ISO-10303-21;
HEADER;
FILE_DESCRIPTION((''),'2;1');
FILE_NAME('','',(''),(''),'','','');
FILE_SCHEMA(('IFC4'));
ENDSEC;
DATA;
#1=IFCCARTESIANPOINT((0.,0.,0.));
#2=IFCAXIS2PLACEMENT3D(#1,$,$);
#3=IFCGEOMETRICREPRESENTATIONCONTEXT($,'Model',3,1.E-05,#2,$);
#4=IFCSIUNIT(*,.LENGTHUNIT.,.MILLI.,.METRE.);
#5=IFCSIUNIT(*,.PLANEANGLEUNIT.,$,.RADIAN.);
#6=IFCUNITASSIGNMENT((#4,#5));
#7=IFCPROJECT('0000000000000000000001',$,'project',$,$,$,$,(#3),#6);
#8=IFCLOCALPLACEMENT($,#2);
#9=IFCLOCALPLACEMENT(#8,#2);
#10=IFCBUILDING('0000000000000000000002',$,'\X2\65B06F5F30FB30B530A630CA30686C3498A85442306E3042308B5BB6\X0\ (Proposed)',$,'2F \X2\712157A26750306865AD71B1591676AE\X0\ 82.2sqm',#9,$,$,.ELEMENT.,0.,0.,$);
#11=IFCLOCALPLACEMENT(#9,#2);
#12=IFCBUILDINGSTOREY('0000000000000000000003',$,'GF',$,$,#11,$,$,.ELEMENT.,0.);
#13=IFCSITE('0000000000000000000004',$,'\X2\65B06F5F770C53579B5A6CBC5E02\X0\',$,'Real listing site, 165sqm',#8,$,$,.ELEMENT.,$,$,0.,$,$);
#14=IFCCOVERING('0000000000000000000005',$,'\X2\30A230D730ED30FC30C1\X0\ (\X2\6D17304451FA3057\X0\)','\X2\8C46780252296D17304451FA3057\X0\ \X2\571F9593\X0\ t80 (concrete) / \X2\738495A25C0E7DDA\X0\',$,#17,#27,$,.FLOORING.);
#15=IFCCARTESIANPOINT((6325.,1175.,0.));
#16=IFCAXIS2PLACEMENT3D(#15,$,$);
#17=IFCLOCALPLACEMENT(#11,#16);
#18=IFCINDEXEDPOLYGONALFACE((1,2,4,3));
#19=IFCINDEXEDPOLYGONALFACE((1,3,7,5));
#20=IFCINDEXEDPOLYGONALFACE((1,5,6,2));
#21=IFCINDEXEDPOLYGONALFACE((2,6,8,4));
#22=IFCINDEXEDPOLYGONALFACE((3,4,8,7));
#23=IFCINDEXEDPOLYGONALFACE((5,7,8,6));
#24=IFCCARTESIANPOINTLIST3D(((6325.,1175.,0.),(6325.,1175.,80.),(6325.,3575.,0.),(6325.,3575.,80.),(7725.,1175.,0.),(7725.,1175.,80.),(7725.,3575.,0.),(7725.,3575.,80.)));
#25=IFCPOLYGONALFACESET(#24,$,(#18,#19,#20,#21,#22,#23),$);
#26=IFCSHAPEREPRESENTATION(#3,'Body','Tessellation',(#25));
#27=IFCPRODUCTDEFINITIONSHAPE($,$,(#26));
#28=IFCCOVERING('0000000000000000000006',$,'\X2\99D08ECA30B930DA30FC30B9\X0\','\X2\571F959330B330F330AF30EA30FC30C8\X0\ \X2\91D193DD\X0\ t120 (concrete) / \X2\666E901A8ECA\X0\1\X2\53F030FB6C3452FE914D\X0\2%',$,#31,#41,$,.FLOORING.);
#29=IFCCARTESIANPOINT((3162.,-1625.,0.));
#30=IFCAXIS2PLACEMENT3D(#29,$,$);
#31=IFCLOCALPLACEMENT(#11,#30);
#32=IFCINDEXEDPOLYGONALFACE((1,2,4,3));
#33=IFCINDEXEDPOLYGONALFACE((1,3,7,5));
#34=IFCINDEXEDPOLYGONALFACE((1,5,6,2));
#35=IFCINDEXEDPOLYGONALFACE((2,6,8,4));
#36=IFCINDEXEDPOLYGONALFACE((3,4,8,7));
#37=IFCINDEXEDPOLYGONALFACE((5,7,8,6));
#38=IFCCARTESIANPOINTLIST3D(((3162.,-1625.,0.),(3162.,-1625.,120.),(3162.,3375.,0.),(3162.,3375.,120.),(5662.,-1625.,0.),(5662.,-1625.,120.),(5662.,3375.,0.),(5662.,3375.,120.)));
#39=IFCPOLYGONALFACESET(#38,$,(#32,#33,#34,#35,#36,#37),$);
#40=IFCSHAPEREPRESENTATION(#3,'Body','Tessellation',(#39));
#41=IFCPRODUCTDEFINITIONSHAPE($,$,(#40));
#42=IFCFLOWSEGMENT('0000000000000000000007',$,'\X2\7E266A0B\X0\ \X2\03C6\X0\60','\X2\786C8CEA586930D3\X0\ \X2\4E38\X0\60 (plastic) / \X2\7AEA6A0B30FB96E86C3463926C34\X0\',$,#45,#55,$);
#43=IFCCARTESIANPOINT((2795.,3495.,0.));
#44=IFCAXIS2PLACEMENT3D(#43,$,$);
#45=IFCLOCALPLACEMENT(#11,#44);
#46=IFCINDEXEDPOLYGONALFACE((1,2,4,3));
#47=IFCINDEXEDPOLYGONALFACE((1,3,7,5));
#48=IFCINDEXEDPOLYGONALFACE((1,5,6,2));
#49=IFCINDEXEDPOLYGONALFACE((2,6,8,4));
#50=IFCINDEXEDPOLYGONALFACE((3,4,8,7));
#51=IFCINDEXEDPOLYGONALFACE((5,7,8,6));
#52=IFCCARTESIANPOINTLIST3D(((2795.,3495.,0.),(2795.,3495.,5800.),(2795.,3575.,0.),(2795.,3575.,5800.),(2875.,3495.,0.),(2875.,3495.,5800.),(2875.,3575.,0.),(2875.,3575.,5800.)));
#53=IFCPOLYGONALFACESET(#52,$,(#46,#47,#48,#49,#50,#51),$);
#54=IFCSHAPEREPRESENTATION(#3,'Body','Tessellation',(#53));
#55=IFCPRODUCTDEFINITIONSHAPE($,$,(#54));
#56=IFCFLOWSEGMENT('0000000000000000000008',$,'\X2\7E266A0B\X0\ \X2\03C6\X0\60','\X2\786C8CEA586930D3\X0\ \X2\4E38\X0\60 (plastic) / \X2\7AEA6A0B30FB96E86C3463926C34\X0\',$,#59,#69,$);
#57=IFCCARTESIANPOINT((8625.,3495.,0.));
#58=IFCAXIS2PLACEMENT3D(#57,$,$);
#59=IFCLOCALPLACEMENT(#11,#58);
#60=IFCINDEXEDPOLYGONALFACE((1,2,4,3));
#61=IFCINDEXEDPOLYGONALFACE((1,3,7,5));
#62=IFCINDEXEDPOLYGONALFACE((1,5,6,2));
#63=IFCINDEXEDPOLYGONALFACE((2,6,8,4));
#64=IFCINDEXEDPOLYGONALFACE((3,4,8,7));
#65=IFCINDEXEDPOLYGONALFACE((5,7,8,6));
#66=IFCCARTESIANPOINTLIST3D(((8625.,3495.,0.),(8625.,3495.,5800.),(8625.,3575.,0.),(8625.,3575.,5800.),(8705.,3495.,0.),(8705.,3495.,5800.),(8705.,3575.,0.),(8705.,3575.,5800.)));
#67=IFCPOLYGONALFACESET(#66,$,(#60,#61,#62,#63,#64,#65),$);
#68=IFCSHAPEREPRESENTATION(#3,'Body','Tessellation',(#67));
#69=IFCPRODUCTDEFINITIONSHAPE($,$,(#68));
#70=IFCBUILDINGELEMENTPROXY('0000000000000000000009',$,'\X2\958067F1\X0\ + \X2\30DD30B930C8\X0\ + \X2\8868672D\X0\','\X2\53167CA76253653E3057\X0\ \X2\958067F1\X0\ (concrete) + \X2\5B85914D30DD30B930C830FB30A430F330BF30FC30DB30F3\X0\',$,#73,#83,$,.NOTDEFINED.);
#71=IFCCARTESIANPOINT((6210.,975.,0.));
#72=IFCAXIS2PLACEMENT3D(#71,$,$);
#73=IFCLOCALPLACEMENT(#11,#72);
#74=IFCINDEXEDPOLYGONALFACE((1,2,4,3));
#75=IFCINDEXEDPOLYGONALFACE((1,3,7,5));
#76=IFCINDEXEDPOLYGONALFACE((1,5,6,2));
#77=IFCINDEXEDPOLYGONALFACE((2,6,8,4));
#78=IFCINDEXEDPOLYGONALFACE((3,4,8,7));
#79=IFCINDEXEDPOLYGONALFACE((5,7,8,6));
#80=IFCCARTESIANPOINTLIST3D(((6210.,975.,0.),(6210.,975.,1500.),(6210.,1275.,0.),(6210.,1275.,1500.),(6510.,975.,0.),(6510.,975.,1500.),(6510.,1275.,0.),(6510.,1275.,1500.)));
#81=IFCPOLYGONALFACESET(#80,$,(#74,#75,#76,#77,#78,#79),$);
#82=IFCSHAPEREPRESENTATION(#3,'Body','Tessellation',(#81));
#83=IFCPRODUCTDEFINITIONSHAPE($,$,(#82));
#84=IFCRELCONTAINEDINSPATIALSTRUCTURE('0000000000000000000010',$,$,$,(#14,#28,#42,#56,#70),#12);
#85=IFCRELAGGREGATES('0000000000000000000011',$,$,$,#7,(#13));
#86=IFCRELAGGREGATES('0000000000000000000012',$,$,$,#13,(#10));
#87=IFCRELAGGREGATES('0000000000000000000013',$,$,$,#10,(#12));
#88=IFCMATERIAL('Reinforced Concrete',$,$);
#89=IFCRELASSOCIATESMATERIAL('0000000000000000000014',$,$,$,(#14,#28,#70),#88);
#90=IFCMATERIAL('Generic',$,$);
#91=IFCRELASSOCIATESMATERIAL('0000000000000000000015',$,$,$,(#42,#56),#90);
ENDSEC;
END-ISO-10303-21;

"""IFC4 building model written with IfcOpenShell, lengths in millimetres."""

from ifc_helpers import new_model, si_unit, frame, frame_2d, origin, place, context, project, spatial, rectangle, extrude, material, element, save


model = new_model("IFC4")

# Units and contexts
model_context = context("Model", 3, precision=1e-05, world=origin())
ifc_project = project(units=[si_unit("LENGTHUNIT", "METRE", prefix="MILLI"), si_unit("PLANEANGLEUNIT", "RADIAN")], contexts=[model_context])

# Site, building, storey
site_placement = place(None, origin())
site = spatial("IfcSite", under=ifc_project, at=site_placement, Name="新潟県南魚沼市", ObjectType="Real listing site, 165sqm", CompositionType="ELEMENT", RefElevation=0.0)
building_placement = place(site_placement, origin())
building = spatial("IfcBuilding", under=site, at=building_placement, Name="新潟・サウナと水風呂のある家 (Proposed)", ObjectType="2F 無垢材と断熱外皮 82.2sqm", CompositionType="ELEMENT", ElevationOfRefHeight=0.0, ElevationOfTerrain=0.0)
storey_placement = place(building_placement, origin())
storey = spatial("IfcBuildingStorey", under=building, at=storey_placement, Name="GF", CompositionType="ELEMENT", Elevation=0.0)

# Shared definitions
ifc_material_1 = material(Name="Reinforced Concrete")

# Coverings
covering_1_placement = place(storey_placement, frame((6325.0, 1175.0, 0.0)))
element("IfcCovering", 1, at=covering_1_placement, inside=storey, material=ifc_material_1, Name="アプローチ (洗い出し)", Description="豆砂利洗い出し 土間 t80 (concrete) / 玄関導線", PredefinedType="FLOORING", context=model_context, shape_type="SweptSolid", body=[
    extrude(rectangle(XDim=1400.0, YDim=2400.0, at=frame_2d((700.0, 1200.0))), frame((6325.0, 1175.0, 0.0)), (0.0, 0.0, 1.0), 80.0),
])
covering_2_placement = place(storey_placement, frame((3162.0, -1625.0, 0.0)))
element("IfcCovering", 2, at=covering_2_placement, inside=storey, material=ifc_material_1, Name="駐車スペース", Description="土間コンクリート 金鏝 t120 (concrete) / 普通車1台・水勾配2%", PredefinedType="FLOORING", context=model_context, shape_type="SweptSolid", body=[
    extrude(rectangle(XDim=2500.0, YDim=5000.0, at=frame_2d((1250.0, 2500.0))), frame((3162.0, -1625.0, 0.0)), (0.0, 0.0, 1.0), 120.0),
])

# Flow segments
ifc_material_2 = material(Name="Generic")
flow_segment_1_placement = place(storey_placement, frame((2795.0, 3495.0, 0.0)))
element("IfcFlowSegment", 3, at=flow_segment_1_placement, inside=storey, material=ifc_material_2, Name="縦樋 φ60", Description="硬質塩ビ 丸60 (plastic) / 竪樋・雨水排水", context=model_context, shape_type="SweptSolid", body=[
    extrude(rectangle(XDim=80.0, YDim=80.0, at=frame_2d((40.0, 40.0))), frame((2795.0, 3495.0, 0.0)), (0.0, 0.0, 1.0), 5800.0),
])
flow_segment_2_placement = place(storey_placement, frame((8625.0, 3495.0, 0.0)))
element("IfcFlowSegment", 4, at=flow_segment_2_placement, inside=storey, material=ifc_material_2, Name="縦樋 φ60", Description="硬質塩ビ 丸60 (plastic) / 竪樋・雨水排水", context=model_context, shape_type="SweptSolid", body=[
    extrude(rectangle(XDim=80.0, YDim=80.0, at=frame_2d((40.0, 40.0))), frame((8625.0, 3495.0, 0.0)), (0.0, 0.0, 1.0), 5800.0),
])

# Building element proxy
proxy_placement = place(storey_placement, frame((6210.0, 975.0, 0.0)))
element("IfcBuildingElementProxy", 5, at=proxy_placement, inside=storey, material=ifc_material_1, Name="門柱 + ポスト + 表札", Description="化粧打放し 門柱 (concrete) + 宅配ポスト・インターホン", PredefinedType="NOTDEFINED", context=model_context, shape_type="SweptSolid", body=[
    extrude(rectangle(XDim=300.0, YDim=300.0, at=frame_2d((150.0, 150.0))), frame((6210.0, 975.0, 0.0)), (0.0, 0.0, 1.0), 1500.0),
])

save(model, "model.ifc")
